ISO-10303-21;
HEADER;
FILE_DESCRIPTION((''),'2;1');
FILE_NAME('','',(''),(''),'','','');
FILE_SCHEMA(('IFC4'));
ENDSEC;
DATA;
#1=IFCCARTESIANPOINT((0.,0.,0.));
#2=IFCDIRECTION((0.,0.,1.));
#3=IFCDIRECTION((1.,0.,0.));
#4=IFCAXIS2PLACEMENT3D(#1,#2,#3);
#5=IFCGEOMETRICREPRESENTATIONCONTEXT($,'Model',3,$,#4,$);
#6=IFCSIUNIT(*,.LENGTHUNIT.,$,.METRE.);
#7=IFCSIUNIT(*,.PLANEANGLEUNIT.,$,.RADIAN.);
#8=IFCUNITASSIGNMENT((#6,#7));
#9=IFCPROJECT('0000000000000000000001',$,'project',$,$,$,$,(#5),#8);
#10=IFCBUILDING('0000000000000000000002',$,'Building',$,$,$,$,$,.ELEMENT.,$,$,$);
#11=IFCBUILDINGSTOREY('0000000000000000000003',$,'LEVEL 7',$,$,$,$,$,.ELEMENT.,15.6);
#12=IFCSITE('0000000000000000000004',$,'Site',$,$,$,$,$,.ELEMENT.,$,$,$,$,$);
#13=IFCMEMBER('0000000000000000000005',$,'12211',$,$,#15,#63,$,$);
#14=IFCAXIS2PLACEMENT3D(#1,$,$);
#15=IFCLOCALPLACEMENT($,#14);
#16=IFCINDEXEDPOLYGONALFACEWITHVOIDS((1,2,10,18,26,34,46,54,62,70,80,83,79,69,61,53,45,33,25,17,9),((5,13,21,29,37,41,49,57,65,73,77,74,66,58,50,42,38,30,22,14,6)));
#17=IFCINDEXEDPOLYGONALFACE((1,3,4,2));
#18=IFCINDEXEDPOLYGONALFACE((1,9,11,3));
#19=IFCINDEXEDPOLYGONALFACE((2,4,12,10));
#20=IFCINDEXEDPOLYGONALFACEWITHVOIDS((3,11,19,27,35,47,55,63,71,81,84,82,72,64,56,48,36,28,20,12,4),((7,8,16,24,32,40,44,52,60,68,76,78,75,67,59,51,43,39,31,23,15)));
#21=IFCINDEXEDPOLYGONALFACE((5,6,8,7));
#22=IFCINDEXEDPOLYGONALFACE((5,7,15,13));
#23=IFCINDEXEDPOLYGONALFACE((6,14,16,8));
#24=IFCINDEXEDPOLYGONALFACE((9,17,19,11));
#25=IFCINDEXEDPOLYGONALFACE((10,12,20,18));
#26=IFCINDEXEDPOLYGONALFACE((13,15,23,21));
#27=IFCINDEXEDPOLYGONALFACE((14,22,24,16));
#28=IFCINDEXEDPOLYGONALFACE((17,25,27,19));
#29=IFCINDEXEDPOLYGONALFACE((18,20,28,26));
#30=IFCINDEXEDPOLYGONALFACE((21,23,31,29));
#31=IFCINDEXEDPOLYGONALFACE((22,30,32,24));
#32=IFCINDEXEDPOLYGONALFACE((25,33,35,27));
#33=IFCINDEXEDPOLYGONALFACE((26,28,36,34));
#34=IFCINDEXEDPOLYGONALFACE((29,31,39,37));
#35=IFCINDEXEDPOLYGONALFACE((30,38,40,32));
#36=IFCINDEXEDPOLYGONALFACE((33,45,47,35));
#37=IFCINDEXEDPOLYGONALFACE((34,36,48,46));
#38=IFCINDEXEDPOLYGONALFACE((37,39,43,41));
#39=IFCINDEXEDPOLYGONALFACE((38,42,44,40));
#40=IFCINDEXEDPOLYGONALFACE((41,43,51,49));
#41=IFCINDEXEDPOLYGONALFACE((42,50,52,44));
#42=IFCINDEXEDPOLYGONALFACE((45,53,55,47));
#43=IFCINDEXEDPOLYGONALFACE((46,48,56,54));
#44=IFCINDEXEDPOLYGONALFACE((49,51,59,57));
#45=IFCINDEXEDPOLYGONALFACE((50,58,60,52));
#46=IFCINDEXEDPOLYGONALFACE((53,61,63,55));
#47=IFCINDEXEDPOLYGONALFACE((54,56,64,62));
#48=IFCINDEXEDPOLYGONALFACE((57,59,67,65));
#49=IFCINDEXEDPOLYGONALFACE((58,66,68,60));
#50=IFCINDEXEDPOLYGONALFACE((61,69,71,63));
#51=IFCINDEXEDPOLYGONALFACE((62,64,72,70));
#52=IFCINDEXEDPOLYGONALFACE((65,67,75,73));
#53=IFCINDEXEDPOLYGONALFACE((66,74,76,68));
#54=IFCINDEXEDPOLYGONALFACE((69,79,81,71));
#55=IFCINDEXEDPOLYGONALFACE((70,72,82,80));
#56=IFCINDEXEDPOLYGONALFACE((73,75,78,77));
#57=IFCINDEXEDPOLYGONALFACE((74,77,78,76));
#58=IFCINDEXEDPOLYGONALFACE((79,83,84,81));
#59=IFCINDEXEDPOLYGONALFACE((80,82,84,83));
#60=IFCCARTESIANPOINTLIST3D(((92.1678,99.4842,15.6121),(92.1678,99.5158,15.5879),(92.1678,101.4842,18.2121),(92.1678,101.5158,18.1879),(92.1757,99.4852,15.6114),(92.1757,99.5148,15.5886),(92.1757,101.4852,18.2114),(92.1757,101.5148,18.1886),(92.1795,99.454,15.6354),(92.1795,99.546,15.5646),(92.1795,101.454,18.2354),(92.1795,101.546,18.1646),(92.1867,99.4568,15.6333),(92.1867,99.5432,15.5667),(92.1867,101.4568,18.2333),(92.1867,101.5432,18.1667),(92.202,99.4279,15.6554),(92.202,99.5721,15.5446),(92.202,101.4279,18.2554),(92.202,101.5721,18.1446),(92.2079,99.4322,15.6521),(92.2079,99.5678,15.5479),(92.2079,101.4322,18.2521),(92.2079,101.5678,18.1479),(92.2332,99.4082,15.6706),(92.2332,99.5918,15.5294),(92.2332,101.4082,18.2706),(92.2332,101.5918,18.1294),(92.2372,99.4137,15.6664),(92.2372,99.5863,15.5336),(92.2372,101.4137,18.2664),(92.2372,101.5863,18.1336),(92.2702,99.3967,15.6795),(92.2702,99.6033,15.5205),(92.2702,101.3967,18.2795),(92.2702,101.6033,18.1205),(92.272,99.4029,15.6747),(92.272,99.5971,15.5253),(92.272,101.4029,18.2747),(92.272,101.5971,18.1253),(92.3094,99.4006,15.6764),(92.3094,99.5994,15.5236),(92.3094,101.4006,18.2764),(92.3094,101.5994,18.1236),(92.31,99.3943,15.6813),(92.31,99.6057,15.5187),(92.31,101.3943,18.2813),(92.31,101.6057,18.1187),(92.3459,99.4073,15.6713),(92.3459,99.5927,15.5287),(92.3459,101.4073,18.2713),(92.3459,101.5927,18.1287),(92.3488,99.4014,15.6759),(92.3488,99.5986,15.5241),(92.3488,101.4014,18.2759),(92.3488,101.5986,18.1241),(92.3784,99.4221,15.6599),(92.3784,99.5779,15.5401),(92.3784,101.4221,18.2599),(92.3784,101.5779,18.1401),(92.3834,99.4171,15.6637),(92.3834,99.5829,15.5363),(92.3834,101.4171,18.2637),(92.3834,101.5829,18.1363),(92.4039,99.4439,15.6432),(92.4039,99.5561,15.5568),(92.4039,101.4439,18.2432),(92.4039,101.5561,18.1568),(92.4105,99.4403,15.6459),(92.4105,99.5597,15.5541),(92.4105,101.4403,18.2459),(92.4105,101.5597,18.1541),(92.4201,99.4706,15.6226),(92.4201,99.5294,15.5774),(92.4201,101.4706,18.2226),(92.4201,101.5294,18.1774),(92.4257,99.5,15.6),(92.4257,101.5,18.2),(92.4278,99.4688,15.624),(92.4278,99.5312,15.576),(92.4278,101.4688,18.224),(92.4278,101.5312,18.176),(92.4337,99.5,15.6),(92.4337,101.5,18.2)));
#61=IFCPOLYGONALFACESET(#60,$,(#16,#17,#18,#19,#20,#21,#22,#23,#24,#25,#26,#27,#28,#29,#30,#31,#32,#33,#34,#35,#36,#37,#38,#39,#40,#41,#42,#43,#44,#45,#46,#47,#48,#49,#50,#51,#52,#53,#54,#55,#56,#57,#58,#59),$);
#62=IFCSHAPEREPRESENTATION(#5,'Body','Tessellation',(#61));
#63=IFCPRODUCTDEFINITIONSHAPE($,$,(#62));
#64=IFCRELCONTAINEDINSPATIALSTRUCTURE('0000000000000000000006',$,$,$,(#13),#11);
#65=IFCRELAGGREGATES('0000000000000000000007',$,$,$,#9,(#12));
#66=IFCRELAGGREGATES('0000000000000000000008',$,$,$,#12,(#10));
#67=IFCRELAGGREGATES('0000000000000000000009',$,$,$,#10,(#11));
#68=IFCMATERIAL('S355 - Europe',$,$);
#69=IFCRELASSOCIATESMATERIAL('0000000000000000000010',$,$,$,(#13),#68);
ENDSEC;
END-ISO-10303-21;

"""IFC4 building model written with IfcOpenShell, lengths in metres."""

from ifc_helpers import new_model, si_unit, frame, origin_with_axes, origin_2d_with_axis, place, context, project, spatial, hollow_circle, extrude, material, material_profile, profile_set, profile_usage, element, save


model = new_model("IFC4")

# Units and contexts
model_context = context("Model", 3, world=origin_with_axes())
ifc_project = project(units=[si_unit("LENGTHUNIT", "METRE"), si_unit("PLANEANGLEUNIT", "RADIAN")], contexts=[model_context])

# Site, building, storey
site = spatial("IfcSite", under=ifc_project, Name="Site", CompositionType="ELEMENT")
building = spatial("IfcBuilding", under=site, Name="Building", CompositionType="ELEMENT")
storey = spatial("IfcBuildingStorey", under=building, Name="LEVEL 7", CompositionType="ELEMENT", Elevation=15.6)

# Shared definitions
ifc_material = material(Name="S355 - Europe")

# Member
ifc_material_profile_1 = material_profile(ifc_material, hollow_circle(Radius=0.1337, WallThickness=0.008, at=origin_2d_with_axis()))
ifc_profile_set_1 = profile_set([ifc_material_profile_1])
ifc_profile_usage_1 = profile_usage(ifc_profile_set_1, cardinal=10)
member_1_placement = place(None, frame((92.3, 101.5, 18.2), z_axis=(0.0, -0.609711, -0.792624), x_axis=(1.0, 0.0, 0.0)))
element("IfcMember", 1, at=member_1_placement, inside=storey, material=ifc_profile_usage_1, Name="12211", context=model_context, shape_type="SweptSolid", body=[
    extrude(hollow_circle(Radius=0.1337, WallThickness=0.008, at=origin_2d_with_axis()), origin_with_axes(), (0.0, 0.0, 1.0), 3.2802),
])

save(model, "model.ifc")
